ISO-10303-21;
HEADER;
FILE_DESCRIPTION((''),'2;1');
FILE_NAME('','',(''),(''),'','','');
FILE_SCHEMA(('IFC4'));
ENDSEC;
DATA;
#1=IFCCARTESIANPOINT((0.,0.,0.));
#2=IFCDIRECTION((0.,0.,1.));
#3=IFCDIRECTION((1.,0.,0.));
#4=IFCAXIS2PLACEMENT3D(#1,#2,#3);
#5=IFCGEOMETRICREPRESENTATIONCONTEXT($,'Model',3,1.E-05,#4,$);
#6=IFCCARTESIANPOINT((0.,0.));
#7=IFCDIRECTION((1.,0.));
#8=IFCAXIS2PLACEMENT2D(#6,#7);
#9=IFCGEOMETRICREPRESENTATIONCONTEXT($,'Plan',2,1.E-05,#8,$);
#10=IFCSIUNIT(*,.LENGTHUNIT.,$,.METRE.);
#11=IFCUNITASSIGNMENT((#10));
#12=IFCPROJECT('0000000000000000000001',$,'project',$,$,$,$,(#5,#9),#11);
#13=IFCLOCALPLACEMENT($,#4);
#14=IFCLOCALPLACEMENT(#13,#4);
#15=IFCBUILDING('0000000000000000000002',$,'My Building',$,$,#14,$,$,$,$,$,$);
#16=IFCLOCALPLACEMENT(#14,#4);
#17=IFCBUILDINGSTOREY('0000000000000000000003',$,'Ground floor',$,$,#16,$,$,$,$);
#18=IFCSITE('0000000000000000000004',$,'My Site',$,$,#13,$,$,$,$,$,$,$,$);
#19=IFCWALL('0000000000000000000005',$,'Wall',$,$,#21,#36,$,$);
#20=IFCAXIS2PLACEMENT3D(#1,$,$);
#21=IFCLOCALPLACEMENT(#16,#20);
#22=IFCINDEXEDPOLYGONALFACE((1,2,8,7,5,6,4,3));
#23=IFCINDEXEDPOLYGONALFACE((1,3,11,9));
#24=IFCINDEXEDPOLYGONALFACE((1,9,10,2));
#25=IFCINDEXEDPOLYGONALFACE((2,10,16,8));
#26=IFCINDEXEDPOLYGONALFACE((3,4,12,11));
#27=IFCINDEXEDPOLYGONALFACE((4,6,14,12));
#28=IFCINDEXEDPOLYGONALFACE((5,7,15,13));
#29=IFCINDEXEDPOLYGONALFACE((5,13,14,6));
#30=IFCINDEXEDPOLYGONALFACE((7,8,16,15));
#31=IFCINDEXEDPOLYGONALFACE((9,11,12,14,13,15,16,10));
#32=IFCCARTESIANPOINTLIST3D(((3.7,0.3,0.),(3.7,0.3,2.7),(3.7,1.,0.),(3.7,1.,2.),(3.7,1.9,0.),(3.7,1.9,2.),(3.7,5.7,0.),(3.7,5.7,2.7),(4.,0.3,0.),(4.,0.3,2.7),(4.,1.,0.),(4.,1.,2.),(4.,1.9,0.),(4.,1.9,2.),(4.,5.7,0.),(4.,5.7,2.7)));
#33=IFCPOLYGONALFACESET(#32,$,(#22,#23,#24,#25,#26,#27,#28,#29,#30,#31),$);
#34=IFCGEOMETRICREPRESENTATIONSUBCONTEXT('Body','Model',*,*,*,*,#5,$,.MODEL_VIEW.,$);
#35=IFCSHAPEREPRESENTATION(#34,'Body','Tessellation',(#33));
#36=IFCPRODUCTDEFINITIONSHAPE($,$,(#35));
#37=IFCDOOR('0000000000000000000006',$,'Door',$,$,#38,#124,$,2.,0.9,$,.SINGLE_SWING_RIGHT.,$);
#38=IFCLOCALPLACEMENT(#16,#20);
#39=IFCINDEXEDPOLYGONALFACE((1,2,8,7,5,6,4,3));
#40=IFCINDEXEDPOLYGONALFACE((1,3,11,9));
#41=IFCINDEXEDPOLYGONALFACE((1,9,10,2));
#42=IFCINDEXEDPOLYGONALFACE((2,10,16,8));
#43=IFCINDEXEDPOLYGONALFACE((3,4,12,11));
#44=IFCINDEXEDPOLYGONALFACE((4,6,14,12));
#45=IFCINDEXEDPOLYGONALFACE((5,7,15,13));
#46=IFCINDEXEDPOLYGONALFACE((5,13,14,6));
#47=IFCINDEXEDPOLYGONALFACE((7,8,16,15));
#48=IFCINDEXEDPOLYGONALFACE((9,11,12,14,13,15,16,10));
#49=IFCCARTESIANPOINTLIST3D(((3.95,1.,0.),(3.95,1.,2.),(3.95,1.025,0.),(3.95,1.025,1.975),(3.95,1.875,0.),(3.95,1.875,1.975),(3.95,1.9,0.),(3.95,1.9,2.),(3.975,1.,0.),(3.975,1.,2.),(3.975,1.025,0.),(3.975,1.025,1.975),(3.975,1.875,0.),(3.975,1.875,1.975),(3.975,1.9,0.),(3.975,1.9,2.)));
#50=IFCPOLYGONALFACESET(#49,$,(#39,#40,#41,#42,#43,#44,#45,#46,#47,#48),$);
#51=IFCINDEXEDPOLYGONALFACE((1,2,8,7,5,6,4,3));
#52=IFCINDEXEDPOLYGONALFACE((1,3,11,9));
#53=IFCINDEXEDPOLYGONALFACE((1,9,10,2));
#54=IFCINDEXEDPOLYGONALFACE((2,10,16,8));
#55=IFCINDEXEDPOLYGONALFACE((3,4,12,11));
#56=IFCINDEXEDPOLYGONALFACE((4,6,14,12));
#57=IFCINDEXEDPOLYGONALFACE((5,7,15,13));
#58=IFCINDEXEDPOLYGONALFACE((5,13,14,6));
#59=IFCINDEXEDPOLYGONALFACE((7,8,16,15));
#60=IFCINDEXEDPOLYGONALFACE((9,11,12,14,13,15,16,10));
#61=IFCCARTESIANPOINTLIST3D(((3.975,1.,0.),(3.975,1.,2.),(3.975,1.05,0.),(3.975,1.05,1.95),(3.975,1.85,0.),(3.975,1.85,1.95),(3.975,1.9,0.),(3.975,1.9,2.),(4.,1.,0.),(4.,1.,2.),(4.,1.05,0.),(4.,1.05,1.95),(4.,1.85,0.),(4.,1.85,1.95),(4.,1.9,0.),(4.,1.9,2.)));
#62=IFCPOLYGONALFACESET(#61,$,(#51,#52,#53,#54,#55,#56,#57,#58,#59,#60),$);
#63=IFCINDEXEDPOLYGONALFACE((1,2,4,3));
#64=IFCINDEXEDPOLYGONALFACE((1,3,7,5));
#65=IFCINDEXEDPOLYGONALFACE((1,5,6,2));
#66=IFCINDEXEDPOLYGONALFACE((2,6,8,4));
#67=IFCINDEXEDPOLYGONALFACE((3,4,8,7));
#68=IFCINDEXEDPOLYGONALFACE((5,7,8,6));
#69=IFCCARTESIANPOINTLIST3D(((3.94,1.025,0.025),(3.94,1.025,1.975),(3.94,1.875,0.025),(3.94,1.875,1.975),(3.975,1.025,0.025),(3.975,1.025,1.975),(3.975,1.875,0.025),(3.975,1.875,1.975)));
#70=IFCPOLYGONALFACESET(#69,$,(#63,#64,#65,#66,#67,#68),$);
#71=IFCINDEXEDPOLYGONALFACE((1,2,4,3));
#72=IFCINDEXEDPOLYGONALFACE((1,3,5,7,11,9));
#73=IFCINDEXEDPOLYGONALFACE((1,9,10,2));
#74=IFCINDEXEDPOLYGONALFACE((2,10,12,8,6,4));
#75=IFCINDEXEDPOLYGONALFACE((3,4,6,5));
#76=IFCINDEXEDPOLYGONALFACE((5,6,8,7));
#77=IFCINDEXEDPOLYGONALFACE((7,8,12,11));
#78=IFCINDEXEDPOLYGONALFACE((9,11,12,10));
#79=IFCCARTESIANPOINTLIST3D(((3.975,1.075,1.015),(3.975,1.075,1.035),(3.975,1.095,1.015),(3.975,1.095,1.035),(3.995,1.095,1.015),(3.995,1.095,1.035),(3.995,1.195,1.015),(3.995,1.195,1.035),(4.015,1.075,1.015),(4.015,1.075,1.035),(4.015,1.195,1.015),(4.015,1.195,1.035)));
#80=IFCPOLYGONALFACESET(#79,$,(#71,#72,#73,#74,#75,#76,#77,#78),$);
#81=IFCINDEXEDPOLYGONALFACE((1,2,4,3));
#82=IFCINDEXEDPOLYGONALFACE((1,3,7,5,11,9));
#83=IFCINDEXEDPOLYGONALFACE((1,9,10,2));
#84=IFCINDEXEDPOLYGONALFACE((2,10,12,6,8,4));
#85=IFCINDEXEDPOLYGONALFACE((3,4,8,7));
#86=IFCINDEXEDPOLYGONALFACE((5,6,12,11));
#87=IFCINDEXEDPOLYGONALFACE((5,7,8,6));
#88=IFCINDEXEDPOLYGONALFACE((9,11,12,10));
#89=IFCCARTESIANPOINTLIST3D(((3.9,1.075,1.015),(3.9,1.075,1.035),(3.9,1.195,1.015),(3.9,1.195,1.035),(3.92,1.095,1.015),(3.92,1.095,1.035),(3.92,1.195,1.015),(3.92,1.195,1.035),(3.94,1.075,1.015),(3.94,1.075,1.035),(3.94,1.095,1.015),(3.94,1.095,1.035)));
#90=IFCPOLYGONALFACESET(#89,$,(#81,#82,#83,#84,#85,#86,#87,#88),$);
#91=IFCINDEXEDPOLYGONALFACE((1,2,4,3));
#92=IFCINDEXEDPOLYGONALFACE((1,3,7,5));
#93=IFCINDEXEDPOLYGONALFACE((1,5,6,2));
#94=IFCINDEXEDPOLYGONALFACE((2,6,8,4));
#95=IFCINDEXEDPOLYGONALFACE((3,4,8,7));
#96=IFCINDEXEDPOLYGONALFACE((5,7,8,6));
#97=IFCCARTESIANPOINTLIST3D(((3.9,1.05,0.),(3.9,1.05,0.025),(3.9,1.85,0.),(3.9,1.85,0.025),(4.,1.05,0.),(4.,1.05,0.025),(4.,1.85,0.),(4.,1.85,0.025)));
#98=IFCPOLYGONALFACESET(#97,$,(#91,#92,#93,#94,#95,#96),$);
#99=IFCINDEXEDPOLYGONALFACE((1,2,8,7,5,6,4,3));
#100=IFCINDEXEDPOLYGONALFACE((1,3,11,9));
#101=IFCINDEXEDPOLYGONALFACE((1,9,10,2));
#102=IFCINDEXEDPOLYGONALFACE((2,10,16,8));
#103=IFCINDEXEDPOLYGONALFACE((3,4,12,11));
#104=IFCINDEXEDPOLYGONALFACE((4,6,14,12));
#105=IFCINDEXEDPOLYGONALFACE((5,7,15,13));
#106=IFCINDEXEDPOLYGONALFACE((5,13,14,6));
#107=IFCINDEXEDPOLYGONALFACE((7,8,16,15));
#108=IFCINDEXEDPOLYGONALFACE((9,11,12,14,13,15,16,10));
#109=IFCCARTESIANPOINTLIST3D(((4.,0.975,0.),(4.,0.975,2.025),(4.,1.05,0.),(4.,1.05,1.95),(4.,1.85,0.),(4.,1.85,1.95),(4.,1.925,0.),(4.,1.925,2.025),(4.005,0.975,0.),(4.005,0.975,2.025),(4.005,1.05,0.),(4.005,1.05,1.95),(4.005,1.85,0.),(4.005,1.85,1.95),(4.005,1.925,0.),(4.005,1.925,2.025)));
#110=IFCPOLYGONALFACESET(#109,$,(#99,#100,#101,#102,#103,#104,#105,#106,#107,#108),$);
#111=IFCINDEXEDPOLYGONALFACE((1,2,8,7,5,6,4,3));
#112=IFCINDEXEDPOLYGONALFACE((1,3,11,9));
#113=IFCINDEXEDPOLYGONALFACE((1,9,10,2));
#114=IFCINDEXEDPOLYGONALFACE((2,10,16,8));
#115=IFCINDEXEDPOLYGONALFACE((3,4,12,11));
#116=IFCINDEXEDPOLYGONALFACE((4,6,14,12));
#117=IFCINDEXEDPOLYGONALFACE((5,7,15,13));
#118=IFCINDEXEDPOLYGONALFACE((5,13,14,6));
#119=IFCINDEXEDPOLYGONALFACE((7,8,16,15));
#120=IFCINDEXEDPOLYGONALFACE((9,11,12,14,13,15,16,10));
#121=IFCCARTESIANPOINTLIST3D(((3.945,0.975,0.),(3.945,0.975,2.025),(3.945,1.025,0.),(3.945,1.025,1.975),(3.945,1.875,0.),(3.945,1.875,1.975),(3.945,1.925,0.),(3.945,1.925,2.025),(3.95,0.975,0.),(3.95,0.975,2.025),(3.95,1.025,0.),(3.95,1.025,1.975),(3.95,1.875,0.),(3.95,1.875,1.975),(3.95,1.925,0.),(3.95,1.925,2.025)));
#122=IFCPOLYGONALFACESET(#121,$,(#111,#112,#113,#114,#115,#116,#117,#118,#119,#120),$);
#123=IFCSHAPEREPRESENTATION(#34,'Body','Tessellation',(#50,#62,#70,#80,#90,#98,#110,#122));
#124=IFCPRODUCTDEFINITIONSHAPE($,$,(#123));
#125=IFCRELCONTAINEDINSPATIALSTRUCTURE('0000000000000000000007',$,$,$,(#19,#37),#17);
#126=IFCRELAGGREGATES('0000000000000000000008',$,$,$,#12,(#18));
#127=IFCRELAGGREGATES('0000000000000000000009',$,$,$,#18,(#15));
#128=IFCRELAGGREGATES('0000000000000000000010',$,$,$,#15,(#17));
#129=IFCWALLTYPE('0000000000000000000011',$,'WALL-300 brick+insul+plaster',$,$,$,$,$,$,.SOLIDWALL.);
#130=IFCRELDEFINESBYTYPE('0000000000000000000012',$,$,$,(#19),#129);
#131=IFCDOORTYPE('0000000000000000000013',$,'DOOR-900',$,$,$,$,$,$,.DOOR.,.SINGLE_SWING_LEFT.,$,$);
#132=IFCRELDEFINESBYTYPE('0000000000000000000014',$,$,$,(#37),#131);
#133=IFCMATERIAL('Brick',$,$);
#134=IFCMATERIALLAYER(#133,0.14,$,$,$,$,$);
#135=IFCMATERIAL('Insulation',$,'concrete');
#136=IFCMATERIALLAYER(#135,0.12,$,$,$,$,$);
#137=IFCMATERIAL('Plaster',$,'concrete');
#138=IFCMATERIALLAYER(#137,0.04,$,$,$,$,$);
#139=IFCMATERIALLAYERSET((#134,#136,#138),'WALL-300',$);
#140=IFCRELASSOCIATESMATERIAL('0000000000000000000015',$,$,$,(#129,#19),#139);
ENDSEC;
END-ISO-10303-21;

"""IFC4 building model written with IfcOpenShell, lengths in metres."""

from ifc_helpers import new_model, entity, si_unit, frame, origin_with_axes, origin_2d_with_axis, place, context, subcontext, project, spatial, line, indexed_curve, outline, extrude, shape, source, transform, mapped, material, layer, layer_set, layer_usage, type_object, type_shapes, element, fill, save


model = new_model("IFC4")

# Units and contexts
model_context = context("Model", 3, precision=1e-05, world=origin_with_axes())
plan_context = context("Plan", 2, precision=1e-05, world=origin_2d_with_axis())
body_context_1 = subcontext(model_context, "Body", "Model", "MODEL_VIEW")
body_context_2 = subcontext(plan_context, "Body", "Plan", "PLAN_VIEW")
ifc_project = project(units=[si_unit("LENGTHUNIT", "METRE")], contexts=[model_context, plan_context])

# Site, building, storey
site_placement = place(None, origin_with_axes())
site = spatial("IfcSite", under=ifc_project, at=site_placement, Name="My Site")
building_placement = place(site_placement, origin_with_axes())
building = spatial("IfcBuilding", under=site, at=building_placement, Name="My Building")
storey_placement = place(building_placement, origin_with_axes())
storey = spatial("IfcBuildingStorey", under=building, at=storey_placement, Name="Ground floor")

# Shared definitions
ifc_material_1 = material(Name="Brick")

# Shared definitions
ifc_layer_1 = layer(ifc_material_1, 0.14)
ifc_material_2 = material(Name="Insulation", Category="concrete")
ifc_layer_2 = layer(ifc_material_2, 0.12)
ifc_material_3 = material(Name="Plaster", Category="concrete")
ifc_layer_3 = layer(ifc_material_3, 0.04)
ifc_layer_set_1 = layer_set([ifc_layer_1, ifc_layer_2, ifc_layer_3], Name="WALL-300")
wall_type = type_object("IfcWallType", Name="WALL-300 brick+insul+plaster", PredefinedType="SOLIDWALL", material=ifc_layer_set_1)
shared_shape_1 = source(origin_with_axes(), body_context_1, "Body", "SweptSolid", [
    extrude(outline(indexed_curve([(0.0, 0.0), (0.9, 0.0), (0.9, 2.0), (0.0, 2.0)], segments=[line(1, 2, 3, 4, 1)])), frame((0.0, -0.6, 0.0), z_axis=(0.0, -1.0, 0.0), x_axis=(1.0, 0.0, 0.0)), (0.0, 0.0, -1.0), 1.2),
])
door_type = type_object("IfcDoorType", Name="DOOR-900", OperationType="SINGLE_SWING_LEFT", PredefinedType="DOOR")
shared_shape_2 = source(origin_with_axes(), body_context_1, "Body", "SweptSolid", [
    extrude(outline(indexed_curve([(0.0, 0.0), (0.0, 2.0), (0.9, 2.0), (0.9, 0.0), (0.875, 0.0), (0.875, 1.975), (0.025, 1.975), (0.025, 0.0)], segments=[line(1, 2, 3, 4, 5, 6, 7, 8, 1)])), frame((0.0, 0.025, 0.0), z_axis=(0.0, -1.0, 0.0), x_axis=(1.0, 0.0, 0.0)), (0.0, 0.0, -1.0), 0.025),
    extrude(outline(indexed_curve([(0.0, 0.0), (0.0, 2.0), (0.9, 2.0), (0.9, 0.0), (0.85, 0.0), (0.85, 1.95), (0.05, 1.95), (0.05, 0.0)], segments=[line(1, 2, 3, 4, 5, 6, 7, 8, 1)])), frame((0.0, 0.0, 0.0), z_axis=(0.0, -1.0, 0.0), x_axis=(1.0, 0.0, 0.0)), (0.0, 0.0, -1.0), 0.025),
    extrude(outline(indexed_curve([(0.0, 0.0), (0.85, 0.0), (0.85, 0.035), (0.0, 0.035)], segments=[line(1, 2, 3, 4, 1)])), frame((0.025, 0.025, 0.025), z_axis=(0.0, 0.0, 1.0), x_axis=(1.0, 0.0, 0.0)), (0.0, 0.0, 1.0), 1.95),
    extrude(outline(indexed_curve([(0.0, 0.0), (0.0, -0.04), (0.12, -0.04), (0.12, -0.02), (0.02, -0.02), (0.02, 0.0)], segments=[line(1, 2, 3, 4, 5, 6, 1)])), frame((0.075, 0.025, 1.015), z_axis=(0.0, 0.0, 1.0), x_axis=(1.0, 0.0, 0.0)), (0.0, 0.0, 1.0), 0.02),
    extrude(outline(indexed_curve([(0.0, 0.0), (0.0, 0.04), (0.12, 0.04), (0.12, 0.02), (0.02, 0.02), (0.02, 0.0)], segments=[line(1, 2, 3, 4, 5, 6, 1)])), frame((0.075, 0.06, 1.015), z_axis=(0.0, 0.0, 1.0), x_axis=(1.0, 0.0, 0.0)), (0.0, 0.0, 1.0), 0.02),
    extrude(outline(indexed_curve([(0.0, 0.0), (0.8, 0.0), (0.8, 0.1), (0.0, 0.1)], segments=[line(1, 2, 3, 4, 1)])), frame((0.05, 0.0, 0.0), z_axis=(0.0, 0.0, 1.0), x_axis=(1.0, 0.0, 0.0)), (0.0, 0.0, 1.0), 0.025),
    extrude(outline(indexed_curve([(0.0, 0.0), (0.0, 2.025), (0.95, 2.025), (0.95, 0.0), (0.875, 0.0), (0.875, 1.95), (0.075, 1.95), (0.075, 0.0)], segments=[line(1, 2, 3, 4, 5, 6, 7, 8, 1)])), frame((-0.025, -0.005, 0.0), z_axis=(0.0, -1.0, 0.0), x_axis=(1.0, 0.0, 0.0)), (0.0, 0.0, -1.0), 0.005),
    extrude(outline(indexed_curve([(0.0, 0.0), (0.0, 2.025), (0.95, 2.025), (0.95, 0.0), (0.9, 0.0), (0.9, 1.975), (0.05, 1.975), (0.05, 0.0)], segments=[line(1, 2, 3, 4, 5, 6, 7, 8, 1)])), frame((-0.025, 0.05, 0.0), z_axis=(0.0, -1.0, 0.0), x_axis=(1.0, 0.0, 0.0)), (0.0, 0.0, -1.0), 0.005),
])
shared_shape_3 = source(origin_with_axes(), body_context_2, "Body", "Curve2D", [
    entity("IfcIndexedPolyCurve", entity("IfcCartesianPointList2D", [[0.0, 0.0], [0.0, 0.05], [0.025, 0.05], [0.025, 0.025], [0.05, 0.025], [0.05, 0.0]]), [entity("IfcLineIndex", [1, 2, 3, 4, 5, 6, 1])]),
    entity("IfcIndexedPolyCurve", entity("IfcCartesianPointList2D", [[0.9, 0.0], [0.9, 0.05], [0.875, 0.05], [0.875, 0.025], [0.85, 0.025], [0.85, 0.0]]), [entity("IfcLineIndex", [1, 2, 3, 4, 5, 6, 1])]),
    entity("IfcTrimmedCurve", entity("IfcEllipse", entity("IfcAxis2Placement2D", entity("IfcCartesianPoint", [0.84, 0.05]), entity("IfcDirection", [1.0, 0.0])), 0.815, 0.85), [entity("IfcCartesianPoint", [0.84, 0.9])], [entity("IfcCartesianPoint", [0.025, 0.05])], True, "CARTESIAN"),
    entity("IfcIndexedPolyCurve", entity("IfcCartesianPointList2D", [[0.875, 0.05], [0.84, 0.05], [0.84, 0.9], [0.875, 0.9]]), [entity("IfcLineIndex", [1, 2, 3, 4, 1])]),
])
type_shapes(door_type, [shared_shape_2, shared_shape_3])

# Wall, opening, door
ifc_layer_usage_1 = layer_usage(ifc_layer_set_1, "AXIS2", "POSITIVE", 0.0)
wall_1_placement = place(storey_placement, frame((4.0, 0.0, 0.0), z_axis=(0.0, 0.0, 1.0), x_axis=(0.0, 1.0, 0.0)))
wall_1 = element("IfcWall", 1, at=wall_1_placement, inside=storey, type_object=wall_type, material=ifc_layer_usage_1, Name="Wall", context=body_context_1, shape_type="SweptSolid", body=[
    extrude(outline(indexed_curve([(0.3, 0.0), (0.3, 0.3), (5.7, 0.3), (5.7, 0.0)], segments=[line(1, 2, 3, 4, 1)])), origin_with_axes(), (0.0, 0.0, 1.0), 2.7),
])
opening_1_placement = place(wall_1_placement, frame((1.0, 0.0, 0.0), z_axis=(0.0, 0.0, 1.0), x_axis=(1.0, 0.0, 0.0)))
opening_1 = element("IfcOpeningElement", 2, at=opening_1_placement, cuts=wall_1, PredefinedType="OPENING", context=body_context_1, shape_type="MappedRepresentation", body=[
    mapped(shared_shape_1, transform((0.0, 0.0, 0.0), x_axis=(1.0, 0.0, 0.0), y_axis=(0.0, 1.0, 0.0), z_axis=(0.0, 0.0, 1.0), scale=1.0)),
])
door_1_placement = place(opening_1_placement, frame((0.0, 0.0, 0.0), z_axis=(0.0, 0.0, 1.0), x_axis=(1.0, 0.0, 0.0)))
door_1 = element("IfcDoor", 3, at=door_1_placement, inside=storey, type_object=door_type, Name="Door", OperationType="SINGLE_SWING_RIGHT", OverallHeight=2.0, OverallWidth=0.9, shapes=[
    shape(body_context_1, "Body", "MappedRepresentation", [mapped(shared_shape_2, transform((0.0, 0.0, 0.0), x_axis=(1.0, 0.0, 0.0), y_axis=(0.0, 1.0, 0.0), z_axis=(0.0, 0.0, 1.0), scale=1.0))]),
    shape(body_context_2, "Body", "MappedRepresentation", [mapped(shared_shape_3, transform((0.0, 0.0, 0.0), x_axis=(1.0, 0.0, 0.0), y_axis=(0.0, 1.0, 0.0), z_axis=(0.0, 0.0, 1.0), scale=1.0))]),
])
fill(opening_1, door_1)

save(model, "model.ifc")
